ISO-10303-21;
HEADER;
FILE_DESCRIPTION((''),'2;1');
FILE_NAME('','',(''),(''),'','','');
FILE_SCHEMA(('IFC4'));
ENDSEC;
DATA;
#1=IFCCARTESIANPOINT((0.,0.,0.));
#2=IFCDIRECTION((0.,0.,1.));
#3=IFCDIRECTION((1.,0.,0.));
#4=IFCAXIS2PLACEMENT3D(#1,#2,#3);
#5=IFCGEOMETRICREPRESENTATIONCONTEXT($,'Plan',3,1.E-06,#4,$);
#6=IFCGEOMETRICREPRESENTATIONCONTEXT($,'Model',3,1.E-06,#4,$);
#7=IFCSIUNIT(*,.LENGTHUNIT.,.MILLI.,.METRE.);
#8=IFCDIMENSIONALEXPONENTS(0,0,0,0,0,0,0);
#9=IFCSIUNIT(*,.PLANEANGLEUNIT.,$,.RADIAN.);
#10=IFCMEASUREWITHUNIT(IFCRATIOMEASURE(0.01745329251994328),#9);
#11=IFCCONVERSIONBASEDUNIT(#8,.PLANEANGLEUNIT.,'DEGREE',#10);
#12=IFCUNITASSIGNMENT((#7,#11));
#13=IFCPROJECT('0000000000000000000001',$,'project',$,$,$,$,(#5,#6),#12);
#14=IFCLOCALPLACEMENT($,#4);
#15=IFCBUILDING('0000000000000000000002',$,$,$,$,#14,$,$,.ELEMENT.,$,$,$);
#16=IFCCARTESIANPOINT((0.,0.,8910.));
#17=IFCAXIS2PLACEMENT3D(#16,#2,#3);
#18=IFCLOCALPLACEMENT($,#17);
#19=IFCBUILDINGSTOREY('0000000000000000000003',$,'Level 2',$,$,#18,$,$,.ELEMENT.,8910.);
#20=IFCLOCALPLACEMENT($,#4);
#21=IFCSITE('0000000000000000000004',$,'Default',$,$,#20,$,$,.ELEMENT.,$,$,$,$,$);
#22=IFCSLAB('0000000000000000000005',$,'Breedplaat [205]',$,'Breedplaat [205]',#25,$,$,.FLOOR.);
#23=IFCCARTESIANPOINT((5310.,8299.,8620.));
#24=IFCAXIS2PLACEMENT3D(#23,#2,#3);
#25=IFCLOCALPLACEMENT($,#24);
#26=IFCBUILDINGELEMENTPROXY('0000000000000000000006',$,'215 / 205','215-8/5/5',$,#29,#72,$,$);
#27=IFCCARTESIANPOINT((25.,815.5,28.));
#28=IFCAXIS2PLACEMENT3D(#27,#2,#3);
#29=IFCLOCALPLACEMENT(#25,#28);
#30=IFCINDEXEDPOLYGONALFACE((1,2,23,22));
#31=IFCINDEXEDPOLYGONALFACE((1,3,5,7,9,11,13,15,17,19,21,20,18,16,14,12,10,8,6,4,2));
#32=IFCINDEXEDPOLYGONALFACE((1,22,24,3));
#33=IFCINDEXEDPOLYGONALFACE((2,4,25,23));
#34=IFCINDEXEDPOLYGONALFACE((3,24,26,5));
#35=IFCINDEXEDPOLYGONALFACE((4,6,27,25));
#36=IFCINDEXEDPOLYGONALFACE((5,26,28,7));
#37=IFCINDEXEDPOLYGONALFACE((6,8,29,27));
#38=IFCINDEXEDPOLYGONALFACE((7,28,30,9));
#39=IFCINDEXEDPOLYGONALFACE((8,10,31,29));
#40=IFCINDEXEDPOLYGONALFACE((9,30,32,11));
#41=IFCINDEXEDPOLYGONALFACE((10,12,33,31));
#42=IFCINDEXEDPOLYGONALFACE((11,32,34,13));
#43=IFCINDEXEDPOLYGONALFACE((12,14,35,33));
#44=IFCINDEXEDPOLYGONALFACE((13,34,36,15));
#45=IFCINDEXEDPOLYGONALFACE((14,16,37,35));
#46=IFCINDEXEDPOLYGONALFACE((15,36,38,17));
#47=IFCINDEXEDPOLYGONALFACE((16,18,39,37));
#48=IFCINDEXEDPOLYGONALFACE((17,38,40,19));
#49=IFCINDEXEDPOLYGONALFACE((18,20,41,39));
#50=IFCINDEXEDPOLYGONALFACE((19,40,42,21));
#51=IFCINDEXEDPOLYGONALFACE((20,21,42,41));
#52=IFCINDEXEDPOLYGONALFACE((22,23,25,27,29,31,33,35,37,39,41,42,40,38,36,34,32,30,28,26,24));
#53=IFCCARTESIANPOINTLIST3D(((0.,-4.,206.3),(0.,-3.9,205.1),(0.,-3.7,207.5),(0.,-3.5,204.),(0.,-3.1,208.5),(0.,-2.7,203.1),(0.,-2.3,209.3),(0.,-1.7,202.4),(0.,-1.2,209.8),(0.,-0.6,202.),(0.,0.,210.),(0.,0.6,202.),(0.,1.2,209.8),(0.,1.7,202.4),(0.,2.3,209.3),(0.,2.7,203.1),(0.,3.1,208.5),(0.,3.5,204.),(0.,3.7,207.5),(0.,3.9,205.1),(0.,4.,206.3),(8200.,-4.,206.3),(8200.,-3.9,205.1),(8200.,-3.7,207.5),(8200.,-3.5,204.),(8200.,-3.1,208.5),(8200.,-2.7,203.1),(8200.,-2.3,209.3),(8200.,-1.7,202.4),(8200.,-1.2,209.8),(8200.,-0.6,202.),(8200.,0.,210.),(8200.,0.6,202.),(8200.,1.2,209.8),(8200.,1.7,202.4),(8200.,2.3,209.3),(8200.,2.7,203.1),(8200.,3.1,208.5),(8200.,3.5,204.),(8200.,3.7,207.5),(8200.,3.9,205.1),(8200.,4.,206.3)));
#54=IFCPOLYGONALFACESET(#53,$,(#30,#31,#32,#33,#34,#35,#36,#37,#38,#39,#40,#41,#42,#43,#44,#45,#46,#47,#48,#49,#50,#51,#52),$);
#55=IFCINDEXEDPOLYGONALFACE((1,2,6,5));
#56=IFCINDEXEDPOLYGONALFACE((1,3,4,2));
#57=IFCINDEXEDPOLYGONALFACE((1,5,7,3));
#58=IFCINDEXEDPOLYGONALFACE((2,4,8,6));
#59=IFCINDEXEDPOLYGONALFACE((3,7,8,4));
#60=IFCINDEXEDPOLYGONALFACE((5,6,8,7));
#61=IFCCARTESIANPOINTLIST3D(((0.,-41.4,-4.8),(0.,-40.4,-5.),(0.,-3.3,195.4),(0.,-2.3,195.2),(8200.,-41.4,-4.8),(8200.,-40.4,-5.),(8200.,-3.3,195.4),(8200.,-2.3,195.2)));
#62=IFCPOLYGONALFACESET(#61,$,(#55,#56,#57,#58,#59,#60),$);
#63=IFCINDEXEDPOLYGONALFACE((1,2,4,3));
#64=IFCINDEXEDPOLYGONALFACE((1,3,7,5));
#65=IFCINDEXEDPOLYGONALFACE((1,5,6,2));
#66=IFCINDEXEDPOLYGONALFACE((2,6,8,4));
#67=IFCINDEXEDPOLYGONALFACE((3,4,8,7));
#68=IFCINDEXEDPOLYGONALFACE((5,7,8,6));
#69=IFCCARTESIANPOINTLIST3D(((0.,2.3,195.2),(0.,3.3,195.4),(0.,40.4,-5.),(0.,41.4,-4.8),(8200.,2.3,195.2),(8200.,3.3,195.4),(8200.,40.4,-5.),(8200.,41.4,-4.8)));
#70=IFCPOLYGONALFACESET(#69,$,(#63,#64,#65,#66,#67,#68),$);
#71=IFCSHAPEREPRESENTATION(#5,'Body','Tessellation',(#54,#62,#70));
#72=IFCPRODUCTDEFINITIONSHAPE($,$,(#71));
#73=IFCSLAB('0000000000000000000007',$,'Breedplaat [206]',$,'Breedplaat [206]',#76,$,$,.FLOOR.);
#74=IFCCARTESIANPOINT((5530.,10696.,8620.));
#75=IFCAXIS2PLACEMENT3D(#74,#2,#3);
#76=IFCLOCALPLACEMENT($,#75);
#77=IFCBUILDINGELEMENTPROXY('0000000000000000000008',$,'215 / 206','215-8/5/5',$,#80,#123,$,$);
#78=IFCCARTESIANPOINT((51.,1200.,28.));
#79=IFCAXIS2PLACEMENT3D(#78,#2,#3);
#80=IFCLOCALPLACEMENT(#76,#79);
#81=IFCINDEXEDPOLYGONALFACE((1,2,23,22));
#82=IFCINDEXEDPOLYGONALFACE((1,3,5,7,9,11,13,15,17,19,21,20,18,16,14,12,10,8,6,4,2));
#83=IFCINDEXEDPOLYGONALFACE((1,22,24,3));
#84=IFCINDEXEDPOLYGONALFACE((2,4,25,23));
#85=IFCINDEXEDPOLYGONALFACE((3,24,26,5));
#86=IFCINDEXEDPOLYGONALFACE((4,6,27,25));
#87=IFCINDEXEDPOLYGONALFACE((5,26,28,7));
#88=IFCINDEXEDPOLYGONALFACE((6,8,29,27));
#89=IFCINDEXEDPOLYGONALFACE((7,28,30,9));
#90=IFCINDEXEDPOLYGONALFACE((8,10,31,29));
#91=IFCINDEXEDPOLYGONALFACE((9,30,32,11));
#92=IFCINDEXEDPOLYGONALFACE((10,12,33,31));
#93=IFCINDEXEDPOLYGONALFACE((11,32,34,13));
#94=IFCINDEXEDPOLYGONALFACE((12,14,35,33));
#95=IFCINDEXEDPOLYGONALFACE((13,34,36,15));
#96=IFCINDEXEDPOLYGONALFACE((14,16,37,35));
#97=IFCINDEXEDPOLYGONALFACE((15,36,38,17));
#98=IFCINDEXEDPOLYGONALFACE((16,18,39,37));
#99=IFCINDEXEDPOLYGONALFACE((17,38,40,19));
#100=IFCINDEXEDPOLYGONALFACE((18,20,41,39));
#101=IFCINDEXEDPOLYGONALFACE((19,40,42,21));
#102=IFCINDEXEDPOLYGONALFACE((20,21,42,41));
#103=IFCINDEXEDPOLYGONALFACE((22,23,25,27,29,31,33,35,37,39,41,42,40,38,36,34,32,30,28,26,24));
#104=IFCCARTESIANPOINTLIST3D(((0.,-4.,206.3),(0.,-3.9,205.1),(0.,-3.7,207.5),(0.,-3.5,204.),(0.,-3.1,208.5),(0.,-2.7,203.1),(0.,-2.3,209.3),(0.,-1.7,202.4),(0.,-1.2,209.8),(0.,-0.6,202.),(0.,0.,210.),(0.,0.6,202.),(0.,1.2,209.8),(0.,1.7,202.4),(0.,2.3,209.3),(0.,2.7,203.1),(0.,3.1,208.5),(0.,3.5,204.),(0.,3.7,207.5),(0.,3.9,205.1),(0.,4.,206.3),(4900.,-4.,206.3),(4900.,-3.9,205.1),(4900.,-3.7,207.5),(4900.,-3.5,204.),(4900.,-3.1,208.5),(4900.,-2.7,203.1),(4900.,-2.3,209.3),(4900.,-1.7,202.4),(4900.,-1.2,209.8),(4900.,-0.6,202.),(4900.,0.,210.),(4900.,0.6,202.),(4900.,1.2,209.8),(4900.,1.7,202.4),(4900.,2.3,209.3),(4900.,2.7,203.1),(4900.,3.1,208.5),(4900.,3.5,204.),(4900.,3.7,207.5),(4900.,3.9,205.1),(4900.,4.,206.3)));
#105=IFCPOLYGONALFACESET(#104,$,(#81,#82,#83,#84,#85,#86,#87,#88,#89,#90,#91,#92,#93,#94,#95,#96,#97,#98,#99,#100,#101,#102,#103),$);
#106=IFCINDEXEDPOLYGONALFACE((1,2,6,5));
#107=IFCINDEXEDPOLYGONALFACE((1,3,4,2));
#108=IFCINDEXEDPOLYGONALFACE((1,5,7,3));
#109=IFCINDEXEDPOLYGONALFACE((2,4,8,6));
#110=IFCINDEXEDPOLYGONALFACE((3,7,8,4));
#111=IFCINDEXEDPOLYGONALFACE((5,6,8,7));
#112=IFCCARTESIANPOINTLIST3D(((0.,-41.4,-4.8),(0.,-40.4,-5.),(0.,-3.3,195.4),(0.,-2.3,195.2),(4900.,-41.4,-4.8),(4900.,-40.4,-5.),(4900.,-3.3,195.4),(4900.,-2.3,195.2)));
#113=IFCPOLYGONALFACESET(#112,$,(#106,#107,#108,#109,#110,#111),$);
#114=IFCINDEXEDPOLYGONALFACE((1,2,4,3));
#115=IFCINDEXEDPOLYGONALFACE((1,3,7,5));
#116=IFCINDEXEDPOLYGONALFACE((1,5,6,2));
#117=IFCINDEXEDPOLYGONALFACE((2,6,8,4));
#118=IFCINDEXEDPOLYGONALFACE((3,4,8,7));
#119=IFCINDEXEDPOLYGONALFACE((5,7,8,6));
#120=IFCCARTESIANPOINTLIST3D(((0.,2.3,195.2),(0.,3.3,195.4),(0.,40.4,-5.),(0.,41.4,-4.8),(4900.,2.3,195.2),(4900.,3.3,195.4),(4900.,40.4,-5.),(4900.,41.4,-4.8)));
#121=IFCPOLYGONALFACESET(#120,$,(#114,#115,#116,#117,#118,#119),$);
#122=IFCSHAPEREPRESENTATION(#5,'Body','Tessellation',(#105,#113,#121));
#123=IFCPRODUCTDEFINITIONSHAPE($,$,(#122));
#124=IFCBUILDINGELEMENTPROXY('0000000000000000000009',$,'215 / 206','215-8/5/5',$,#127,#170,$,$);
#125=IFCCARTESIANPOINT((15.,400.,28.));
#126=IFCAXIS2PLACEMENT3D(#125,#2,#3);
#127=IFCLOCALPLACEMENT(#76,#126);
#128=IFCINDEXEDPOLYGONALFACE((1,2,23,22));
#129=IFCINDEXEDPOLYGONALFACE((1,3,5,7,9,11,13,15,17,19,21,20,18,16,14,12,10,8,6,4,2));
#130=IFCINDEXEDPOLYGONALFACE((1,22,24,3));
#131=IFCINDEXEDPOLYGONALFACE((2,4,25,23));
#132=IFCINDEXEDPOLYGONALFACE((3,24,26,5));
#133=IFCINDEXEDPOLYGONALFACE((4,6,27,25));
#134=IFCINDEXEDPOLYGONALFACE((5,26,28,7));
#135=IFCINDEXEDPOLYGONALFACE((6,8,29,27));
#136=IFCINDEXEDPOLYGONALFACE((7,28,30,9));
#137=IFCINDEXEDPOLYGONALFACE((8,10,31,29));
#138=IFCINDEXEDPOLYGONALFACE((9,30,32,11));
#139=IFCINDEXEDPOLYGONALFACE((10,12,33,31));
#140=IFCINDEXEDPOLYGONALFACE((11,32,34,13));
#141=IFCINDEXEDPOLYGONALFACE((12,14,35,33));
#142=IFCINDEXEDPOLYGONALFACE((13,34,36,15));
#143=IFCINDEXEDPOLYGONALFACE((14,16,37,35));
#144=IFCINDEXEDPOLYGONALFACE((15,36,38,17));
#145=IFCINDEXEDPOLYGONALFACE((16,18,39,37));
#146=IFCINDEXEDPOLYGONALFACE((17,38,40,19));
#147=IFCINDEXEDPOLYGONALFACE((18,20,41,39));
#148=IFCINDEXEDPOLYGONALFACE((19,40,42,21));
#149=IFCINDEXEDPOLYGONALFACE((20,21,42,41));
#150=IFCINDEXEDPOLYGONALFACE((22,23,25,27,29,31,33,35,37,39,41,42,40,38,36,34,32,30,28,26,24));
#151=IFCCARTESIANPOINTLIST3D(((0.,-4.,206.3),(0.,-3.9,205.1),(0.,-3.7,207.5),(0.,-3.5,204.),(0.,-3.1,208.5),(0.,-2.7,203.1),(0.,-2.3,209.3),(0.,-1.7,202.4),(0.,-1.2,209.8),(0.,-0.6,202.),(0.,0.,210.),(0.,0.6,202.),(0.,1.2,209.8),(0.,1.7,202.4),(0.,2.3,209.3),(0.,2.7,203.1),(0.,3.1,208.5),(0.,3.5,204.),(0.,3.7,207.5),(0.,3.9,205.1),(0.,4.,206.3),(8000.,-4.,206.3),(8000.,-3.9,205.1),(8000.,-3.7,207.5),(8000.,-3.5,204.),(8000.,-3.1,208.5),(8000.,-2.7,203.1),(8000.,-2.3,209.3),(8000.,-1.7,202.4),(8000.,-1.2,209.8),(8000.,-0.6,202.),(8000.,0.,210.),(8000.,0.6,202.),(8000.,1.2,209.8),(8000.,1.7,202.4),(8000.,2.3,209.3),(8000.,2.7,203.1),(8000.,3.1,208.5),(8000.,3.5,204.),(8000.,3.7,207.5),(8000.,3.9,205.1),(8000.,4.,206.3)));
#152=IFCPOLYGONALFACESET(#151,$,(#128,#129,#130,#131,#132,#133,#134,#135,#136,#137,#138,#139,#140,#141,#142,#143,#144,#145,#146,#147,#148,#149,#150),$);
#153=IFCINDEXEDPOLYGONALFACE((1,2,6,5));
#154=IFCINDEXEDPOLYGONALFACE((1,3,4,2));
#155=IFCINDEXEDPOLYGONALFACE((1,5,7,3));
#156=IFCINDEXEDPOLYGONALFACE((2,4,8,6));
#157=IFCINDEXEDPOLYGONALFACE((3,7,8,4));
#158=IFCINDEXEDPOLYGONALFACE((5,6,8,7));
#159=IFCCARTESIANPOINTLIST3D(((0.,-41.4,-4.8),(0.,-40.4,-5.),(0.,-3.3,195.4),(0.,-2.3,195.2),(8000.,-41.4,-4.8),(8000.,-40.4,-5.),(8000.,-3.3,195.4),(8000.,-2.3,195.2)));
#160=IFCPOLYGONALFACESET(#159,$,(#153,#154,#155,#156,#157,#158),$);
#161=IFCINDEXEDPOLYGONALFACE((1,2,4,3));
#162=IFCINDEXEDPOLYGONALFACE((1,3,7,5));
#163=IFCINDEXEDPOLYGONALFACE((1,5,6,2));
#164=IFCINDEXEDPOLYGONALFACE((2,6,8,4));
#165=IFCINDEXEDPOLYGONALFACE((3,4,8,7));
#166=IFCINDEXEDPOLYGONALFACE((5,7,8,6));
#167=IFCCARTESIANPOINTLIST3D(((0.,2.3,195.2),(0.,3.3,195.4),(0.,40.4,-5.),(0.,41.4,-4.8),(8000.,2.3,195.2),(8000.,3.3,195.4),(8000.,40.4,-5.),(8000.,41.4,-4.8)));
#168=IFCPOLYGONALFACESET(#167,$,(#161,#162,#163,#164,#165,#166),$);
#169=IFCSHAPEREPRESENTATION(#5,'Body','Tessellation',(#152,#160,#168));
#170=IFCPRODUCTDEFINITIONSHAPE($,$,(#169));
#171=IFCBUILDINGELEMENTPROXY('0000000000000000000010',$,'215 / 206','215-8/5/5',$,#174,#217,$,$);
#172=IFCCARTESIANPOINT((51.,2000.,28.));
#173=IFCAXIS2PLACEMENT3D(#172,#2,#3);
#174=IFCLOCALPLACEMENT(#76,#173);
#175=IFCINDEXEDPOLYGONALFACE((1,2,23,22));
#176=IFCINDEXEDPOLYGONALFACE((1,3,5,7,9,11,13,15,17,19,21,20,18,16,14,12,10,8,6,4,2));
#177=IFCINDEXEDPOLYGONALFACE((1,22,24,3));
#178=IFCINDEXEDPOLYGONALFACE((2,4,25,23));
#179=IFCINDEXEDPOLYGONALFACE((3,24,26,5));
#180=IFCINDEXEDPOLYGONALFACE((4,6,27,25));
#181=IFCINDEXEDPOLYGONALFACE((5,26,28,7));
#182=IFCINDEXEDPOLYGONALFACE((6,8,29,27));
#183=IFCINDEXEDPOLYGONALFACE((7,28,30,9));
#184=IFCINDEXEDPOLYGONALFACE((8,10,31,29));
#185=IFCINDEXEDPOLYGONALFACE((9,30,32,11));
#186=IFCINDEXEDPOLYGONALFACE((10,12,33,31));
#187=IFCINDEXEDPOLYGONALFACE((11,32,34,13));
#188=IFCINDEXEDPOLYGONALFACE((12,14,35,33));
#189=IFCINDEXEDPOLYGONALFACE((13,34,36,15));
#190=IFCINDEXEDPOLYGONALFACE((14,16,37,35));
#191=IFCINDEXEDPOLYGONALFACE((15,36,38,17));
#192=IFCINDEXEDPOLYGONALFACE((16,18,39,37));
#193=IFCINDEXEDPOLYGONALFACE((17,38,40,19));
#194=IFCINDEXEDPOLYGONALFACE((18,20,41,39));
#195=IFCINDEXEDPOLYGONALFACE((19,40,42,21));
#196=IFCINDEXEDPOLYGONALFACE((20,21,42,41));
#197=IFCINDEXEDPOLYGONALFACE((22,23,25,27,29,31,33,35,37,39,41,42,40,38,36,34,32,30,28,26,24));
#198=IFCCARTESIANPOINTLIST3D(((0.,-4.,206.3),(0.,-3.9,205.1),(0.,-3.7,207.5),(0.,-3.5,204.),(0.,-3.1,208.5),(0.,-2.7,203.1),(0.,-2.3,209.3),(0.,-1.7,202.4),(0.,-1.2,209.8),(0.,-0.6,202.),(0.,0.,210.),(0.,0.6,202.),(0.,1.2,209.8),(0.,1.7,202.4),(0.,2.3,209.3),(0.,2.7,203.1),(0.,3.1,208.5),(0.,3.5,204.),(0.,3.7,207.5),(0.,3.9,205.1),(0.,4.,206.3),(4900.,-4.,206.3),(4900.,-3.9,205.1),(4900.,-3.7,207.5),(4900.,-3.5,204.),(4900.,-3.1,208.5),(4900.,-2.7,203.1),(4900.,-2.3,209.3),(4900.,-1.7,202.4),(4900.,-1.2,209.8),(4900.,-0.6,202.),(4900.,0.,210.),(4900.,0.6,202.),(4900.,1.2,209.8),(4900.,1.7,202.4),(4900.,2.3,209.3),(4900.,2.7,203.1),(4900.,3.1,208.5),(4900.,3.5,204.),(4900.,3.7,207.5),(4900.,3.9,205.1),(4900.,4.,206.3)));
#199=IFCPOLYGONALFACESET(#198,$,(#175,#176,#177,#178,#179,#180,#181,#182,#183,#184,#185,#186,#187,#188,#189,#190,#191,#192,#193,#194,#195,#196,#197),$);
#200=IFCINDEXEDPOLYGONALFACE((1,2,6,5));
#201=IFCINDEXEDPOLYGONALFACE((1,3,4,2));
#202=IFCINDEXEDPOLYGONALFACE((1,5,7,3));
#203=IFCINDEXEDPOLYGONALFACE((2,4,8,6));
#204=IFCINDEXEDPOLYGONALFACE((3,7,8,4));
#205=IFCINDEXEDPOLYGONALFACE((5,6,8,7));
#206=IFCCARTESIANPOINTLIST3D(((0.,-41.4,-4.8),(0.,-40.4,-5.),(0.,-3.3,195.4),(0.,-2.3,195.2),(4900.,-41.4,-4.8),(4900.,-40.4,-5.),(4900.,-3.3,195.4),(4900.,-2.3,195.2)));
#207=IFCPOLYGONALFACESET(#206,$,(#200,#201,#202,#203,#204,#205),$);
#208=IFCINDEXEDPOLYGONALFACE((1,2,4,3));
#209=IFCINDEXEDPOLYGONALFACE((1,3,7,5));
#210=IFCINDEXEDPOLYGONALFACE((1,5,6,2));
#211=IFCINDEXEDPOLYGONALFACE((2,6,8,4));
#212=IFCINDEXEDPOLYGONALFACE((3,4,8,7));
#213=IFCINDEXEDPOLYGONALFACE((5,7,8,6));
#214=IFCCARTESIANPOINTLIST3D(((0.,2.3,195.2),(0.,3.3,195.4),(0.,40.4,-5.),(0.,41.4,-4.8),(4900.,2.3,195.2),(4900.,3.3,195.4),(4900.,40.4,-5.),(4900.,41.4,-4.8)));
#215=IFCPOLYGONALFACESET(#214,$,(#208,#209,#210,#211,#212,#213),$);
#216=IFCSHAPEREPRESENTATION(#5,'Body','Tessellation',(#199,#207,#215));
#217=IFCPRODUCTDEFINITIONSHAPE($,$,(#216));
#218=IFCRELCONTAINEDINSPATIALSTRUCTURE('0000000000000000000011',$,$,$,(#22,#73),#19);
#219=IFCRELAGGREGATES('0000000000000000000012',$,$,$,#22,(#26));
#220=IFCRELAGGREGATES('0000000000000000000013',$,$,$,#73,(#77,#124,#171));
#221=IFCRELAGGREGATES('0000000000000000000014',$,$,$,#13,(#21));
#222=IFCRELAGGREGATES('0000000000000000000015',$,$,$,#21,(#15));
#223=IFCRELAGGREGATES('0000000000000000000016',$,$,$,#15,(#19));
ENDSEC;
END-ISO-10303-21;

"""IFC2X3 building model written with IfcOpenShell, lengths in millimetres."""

from ifc_helpers import new_model, entity, si_unit, converted_unit, frame, origin_with_axes, origin_2d_with_axis, place, context, project, spatial, rectangle, circle, extrude, element, aggregate, save


model = new_model("IFC2X3")

# Units and contexts
plan_context = context("Plan", 3, precision=1e-06, world=origin_with_axes())
model_context = context("Model", 3, precision=1e-06, world=origin_with_axes())
ifc_project = project(units=[si_unit("LENGTHUNIT", "METRE", prefix="MILLI"), converted_unit("PLANEANGLEUNIT", "DEGREE", entity("IfcRatioMeasure", 0.01745329251994328), si_unit("PLANEANGLEUNIT", "RADIAN"), dimensions=[0, 0, 0, 0, 0, 0, 0])], contexts=[plan_context, model_context])

# Site, building, storey
site_placement = place(None, origin_with_axes())
site = spatial("IfcSite", under=ifc_project, at=site_placement, Name="Default", CompositionType="ELEMENT")
building_placement = place(None, origin_with_axes())
building = spatial("IfcBuilding", under=site, at=building_placement, CompositionType="ELEMENT")
storey_placement = place(None, frame((0.0, 0.0, 8910.0), z_axis=(0.0, 0.0, 1.0), x_axis=(1.0, 0.0, 0.0)))
storey = spatial("IfcBuildingStorey", under=building, at=storey_placement, Name="Level 2", CompositionType="ELEMENT", Elevation=8910.0)

# Slab, building element proxy
slab_1_placement = place(None, frame((5310.0, 8299.0, 8620.0), z_axis=(0.0, 0.0, 1.0), x_axis=(1.0, 0.0, 0.0)))
slab_1 = element("IfcSlab", 1, at=slab_1_placement, inside=storey, Name="Breedplaat [205]", ObjectType="Breedplaat [205]", PredefinedType="FLOOR")
proxy_1_placement = place(slab_1_placement, frame((25.0, 815.5, 28.0), z_axis=(0.0, 0.0, 1.0), x_axis=(1.0, 0.0, 0.0)))
proxy_1 = element("IfcBuildingElementProxy", 2, at=proxy_1_placement, Name="215 / 205", Description="215-8/5/5", context=plan_context, shape_type="SweptSolid", body=[
    extrude(circle(Radius=4.0, at=origin_2d_with_axis()), frame((0.0, 0.0, 206.0), z_axis=(1.0, 0.0, 0.0), x_axis=(0.0, 0.0, 1.0)), (0.0, 0.0, 1.0), 8200.0),
    extrude(rectangle(XDim=203.8, YDim=1.0, at=origin_2d_with_axis()), frame((0.0, -21.9, 95.2), z_axis=(1.0, 0.0, 0.0), x_axis=(0.0, 0.187112, 0.982339)), (0.0, 0.0, 1.0), 8200.0),
    extrude(rectangle(XDim=203.8, YDim=1.0, at=origin_2d_with_axis()), frame((0.0, 21.9, 95.2), z_axis=(1.0, 0.0, 0.0), x_axis=(0.0, -0.187112, 0.982339)), (0.0, 0.0, 1.0), 8200.0),
])
aggregate(slab_1, [proxy_1])

# Slab, building element proxies
slab_2_placement = place(None, frame((5530.0, 10696.0, 8620.0), z_axis=(0.0, 0.0, 1.0), x_axis=(1.0, 0.0, 0.0)))
slab_2 = element("IfcSlab", 3, at=slab_2_placement, inside=storey, Name="Breedplaat [206]", ObjectType="Breedplaat [206]", PredefinedType="FLOOR")
proxy_2_placement = place(slab_2_placement, frame((51.0, 1200.0, 28.0), z_axis=(0.0, 0.0, 1.0), x_axis=(1.0, 0.0, 0.0)))
proxy_2 = element("IfcBuildingElementProxy", 4, at=proxy_2_placement, Name="215 / 206", Description="215-8/5/5", context=plan_context, shape_type="SweptSolid", body=[
    extrude(circle(Radius=4.0, at=origin_2d_with_axis()), frame((0.0, 0.0, 206.0), z_axis=(1.0, 0.0, 0.0), x_axis=(0.0, 0.0, 1.0)), (0.0, 0.0, 1.0), 4900.0),
    extrude(rectangle(XDim=203.8, YDim=1.0, at=origin_2d_with_axis()), frame((0.0, -21.9, 95.2), z_axis=(1.0, 0.0, 0.0), x_axis=(0.0, 0.187112, 0.982339)), (0.0, 0.0, 1.0), 4900.0),
    extrude(rectangle(XDim=203.8, YDim=1.0, at=origin_2d_with_axis()), frame((0.0, 21.9, 95.2), z_axis=(1.0, 0.0, 0.0), x_axis=(0.0, -0.187112, 0.982339)), (0.0, 0.0, 1.0), 4900.0),
])
proxy_3_placement = place(slab_2_placement, frame((15.0, 400.0, 28.0), z_axis=(0.0, 0.0, 1.0), x_axis=(1.0, 0.0, 0.0)))
proxy_3 = element("IfcBuildingElementProxy", 5, at=proxy_3_placement, Name="215 / 206", Description="215-8/5/5", context=plan_context, shape_type="SweptSolid", body=[
    extrude(circle(Radius=4.0, at=origin_2d_with_axis()), frame((0.0, 0.0, 206.0), z_axis=(1.0, 0.0, 0.0), x_axis=(0.0, 0.0, 1.0)), (0.0, 0.0, 1.0), 8000.0),
    extrude(rectangle(XDim=203.8, YDim=1.0, at=origin_2d_with_axis()), frame((0.0, -21.9, 95.2), z_axis=(1.0, 0.0, 0.0), x_axis=(0.0, 0.187112, 0.982339)), (0.0, 0.0, 1.0), 8000.0),
    extrude(rectangle(XDim=203.8, YDim=1.0, at=origin_2d_with_axis()), frame((0.0, 21.9, 95.2), z_axis=(1.0, 0.0, 0.0), x_axis=(0.0, -0.187112, 0.982339)), (0.0, 0.0, 1.0), 8000.0),
])
proxy_4_placement = place(slab_2_placement, frame((51.0, 2000.0, 28.0), z_axis=(0.0, 0.0, 1.0), x_axis=(1.0, 0.0, 0.0)))
proxy_4 = element("IfcBuildingElementProxy", 6, at=proxy_4_placement, Name="215 / 206", Description="215-8/5/5", context=plan_context, shape_type="SweptSolid", body=[
    extrude(circle(Radius=4.0, at=origin_2d_with_axis()), frame((0.0, 0.0, 206.0), z_axis=(1.0, 0.0, 0.0), x_axis=(0.0, 0.0, 1.0)), (0.0, 0.0, 1.0), 4900.0),
    extrude(rectangle(XDim=203.8, YDim=1.0, at=origin_2d_with_axis()), frame((0.0, -21.9, 95.2), z_axis=(1.0, 0.0, 0.0), x_axis=(0.0, 0.187112, 0.982339)), (0.0, 0.0, 1.0), 4900.0),
    extrude(rectangle(XDim=203.8, YDim=1.0, at=origin_2d_with_axis()), frame((0.0, 21.9, 95.2), z_axis=(1.0, 0.0, 0.0), x_axis=(0.0, -0.187112, 0.982339)), (0.0, 0.0, 1.0), 4900.0),
])
aggregate(slab_2, [proxy_2, proxy_3, proxy_4])

save(model, "model.ifc")
